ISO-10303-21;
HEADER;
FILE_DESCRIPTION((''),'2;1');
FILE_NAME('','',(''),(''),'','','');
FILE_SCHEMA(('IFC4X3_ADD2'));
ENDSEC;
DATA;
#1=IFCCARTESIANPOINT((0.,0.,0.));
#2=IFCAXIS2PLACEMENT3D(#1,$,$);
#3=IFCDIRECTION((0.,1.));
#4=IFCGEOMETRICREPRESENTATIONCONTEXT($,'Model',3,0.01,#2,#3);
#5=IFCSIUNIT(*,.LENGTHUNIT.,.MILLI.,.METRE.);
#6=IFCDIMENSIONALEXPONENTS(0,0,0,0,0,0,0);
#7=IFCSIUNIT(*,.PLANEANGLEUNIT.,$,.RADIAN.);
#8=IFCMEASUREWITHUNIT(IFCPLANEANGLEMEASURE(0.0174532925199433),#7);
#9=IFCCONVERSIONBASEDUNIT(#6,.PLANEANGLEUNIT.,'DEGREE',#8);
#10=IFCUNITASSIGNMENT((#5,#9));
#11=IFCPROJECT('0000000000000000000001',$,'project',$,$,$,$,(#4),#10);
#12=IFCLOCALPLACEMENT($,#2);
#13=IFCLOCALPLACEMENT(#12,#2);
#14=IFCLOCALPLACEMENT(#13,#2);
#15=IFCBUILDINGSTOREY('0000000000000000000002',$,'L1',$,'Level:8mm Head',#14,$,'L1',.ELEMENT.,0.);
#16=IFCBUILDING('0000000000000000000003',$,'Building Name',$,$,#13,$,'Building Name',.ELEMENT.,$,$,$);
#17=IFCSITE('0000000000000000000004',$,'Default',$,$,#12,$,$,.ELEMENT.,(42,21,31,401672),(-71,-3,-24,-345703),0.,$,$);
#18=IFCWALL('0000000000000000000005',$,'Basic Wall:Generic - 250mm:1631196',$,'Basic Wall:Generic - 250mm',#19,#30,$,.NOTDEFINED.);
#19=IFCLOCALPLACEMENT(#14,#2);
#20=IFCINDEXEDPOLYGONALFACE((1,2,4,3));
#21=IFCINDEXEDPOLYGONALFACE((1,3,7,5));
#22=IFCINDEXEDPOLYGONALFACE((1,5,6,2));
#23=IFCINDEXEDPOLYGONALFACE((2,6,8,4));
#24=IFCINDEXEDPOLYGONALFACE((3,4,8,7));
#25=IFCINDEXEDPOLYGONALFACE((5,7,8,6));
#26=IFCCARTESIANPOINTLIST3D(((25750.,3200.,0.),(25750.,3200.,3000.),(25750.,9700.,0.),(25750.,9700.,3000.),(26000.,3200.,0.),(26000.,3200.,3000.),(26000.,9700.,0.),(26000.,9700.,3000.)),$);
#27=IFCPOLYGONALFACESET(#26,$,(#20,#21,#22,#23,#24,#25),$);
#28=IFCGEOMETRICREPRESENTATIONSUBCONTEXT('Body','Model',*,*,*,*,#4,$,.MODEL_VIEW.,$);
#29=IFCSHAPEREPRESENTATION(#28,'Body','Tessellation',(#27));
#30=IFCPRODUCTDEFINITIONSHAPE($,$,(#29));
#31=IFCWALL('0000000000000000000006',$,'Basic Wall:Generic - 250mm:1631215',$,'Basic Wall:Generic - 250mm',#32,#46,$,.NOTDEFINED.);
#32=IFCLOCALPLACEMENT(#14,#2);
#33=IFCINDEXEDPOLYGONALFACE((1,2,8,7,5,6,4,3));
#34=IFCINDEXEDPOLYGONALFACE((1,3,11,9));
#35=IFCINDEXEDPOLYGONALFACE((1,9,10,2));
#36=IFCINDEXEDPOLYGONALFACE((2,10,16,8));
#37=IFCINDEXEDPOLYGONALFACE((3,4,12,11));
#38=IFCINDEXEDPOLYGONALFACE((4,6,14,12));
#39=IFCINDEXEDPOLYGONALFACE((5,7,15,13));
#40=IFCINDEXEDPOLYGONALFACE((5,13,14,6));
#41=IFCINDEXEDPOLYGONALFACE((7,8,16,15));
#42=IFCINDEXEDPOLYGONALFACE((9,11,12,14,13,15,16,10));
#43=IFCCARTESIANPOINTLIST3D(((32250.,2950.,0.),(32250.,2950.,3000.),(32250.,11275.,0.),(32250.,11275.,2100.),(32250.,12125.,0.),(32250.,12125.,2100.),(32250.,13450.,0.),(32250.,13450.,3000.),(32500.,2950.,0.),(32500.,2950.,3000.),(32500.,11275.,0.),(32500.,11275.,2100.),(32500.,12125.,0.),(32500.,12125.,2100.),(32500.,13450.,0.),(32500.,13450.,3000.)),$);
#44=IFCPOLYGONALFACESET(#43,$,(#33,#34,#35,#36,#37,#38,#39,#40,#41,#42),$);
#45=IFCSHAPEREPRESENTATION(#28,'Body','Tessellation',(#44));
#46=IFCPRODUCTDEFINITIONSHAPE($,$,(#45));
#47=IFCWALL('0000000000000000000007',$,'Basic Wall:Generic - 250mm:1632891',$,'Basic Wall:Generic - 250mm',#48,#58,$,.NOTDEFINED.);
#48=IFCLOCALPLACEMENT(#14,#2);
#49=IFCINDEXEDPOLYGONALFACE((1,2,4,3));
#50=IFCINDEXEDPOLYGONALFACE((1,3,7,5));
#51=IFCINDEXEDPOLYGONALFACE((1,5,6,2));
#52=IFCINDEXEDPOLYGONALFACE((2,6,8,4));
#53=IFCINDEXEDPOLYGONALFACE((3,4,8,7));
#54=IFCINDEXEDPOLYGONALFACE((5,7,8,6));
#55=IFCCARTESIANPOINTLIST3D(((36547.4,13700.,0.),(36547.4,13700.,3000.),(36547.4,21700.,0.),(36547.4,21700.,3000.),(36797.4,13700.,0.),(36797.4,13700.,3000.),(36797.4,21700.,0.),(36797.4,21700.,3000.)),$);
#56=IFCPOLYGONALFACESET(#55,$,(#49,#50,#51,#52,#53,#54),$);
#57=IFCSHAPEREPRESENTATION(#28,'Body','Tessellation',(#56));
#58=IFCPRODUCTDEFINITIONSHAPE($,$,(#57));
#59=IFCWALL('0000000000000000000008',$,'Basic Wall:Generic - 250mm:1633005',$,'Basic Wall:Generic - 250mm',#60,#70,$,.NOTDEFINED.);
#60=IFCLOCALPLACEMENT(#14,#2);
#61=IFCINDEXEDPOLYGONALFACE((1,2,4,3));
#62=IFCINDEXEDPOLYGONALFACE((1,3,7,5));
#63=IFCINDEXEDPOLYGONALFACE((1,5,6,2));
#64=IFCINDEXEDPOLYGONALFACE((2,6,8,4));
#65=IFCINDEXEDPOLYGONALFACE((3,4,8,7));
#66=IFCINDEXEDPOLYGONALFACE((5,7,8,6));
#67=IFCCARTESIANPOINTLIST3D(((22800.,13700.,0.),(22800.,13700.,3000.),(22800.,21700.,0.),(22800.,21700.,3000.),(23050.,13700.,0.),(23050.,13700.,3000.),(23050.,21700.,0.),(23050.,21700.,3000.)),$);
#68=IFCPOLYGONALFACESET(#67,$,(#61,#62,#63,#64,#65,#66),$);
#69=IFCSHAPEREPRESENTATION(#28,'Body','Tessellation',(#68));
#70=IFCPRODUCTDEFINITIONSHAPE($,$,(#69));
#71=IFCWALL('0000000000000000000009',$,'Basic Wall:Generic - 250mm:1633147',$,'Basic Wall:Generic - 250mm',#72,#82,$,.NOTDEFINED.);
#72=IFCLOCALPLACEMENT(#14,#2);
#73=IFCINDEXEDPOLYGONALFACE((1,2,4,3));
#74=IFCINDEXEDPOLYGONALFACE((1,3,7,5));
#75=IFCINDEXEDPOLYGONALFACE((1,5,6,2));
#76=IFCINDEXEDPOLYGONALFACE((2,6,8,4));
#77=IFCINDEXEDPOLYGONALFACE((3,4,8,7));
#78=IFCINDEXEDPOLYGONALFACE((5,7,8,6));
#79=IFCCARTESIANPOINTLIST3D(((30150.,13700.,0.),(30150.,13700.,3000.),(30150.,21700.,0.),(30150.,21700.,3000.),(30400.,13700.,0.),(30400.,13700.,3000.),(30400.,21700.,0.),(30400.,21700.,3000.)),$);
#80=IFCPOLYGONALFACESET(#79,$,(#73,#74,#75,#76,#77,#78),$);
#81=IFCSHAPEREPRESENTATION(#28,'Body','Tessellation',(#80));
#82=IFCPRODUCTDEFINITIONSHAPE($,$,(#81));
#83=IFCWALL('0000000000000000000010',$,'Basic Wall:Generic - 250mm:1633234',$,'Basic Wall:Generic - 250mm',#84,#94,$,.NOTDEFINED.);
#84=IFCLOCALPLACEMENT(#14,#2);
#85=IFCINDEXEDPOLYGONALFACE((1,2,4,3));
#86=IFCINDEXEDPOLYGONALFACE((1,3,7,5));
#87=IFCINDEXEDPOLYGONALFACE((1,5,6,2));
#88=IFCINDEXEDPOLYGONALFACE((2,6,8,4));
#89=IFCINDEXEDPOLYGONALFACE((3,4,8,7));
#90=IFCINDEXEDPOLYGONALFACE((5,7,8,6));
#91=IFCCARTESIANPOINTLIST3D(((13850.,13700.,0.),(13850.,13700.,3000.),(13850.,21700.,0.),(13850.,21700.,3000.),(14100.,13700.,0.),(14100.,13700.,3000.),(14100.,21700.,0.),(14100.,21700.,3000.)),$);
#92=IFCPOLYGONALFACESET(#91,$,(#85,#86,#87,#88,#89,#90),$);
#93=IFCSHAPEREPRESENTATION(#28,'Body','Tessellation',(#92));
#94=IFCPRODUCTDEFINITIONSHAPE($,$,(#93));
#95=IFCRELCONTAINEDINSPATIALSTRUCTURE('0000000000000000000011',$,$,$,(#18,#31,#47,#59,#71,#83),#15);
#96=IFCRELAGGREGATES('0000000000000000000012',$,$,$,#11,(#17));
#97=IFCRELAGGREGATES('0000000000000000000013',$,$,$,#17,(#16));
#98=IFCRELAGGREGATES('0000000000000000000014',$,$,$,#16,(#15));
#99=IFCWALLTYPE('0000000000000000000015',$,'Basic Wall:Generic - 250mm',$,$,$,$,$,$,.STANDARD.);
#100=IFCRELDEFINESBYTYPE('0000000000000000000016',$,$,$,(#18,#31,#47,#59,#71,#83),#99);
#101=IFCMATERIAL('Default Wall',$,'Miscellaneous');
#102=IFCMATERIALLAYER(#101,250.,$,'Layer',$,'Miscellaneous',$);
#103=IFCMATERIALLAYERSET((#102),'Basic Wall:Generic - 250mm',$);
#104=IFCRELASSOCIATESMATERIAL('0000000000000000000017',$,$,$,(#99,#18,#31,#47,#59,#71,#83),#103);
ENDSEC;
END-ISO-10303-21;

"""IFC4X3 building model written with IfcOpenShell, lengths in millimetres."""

from ifc_helpers import new_model, entity, si_unit, converted_unit, direction, frame, frame_2d, origin, place, context, subcontext, project, spatial, rectangle, extrude, material, layer, layer_set, type_object, element, save


model = new_model("IFC4X3")

# Units and contexts
model_context = context("Model", 3, precision=0.01, world=origin(), true_north=direction((0.0, 1.0)))
body_context = subcontext(model_context, "Body", "Model", "MODEL_VIEW")
ifc_project = project(units=[si_unit("LENGTHUNIT", "METRE", prefix="MILLI"), converted_unit("PLANEANGLEUNIT", "DEGREE", entity("IfcPlaneAngleMeasure", 0.0174532925199433), si_unit("PLANEANGLEUNIT", "RADIAN"), dimensions=[0, 0, 0, 0, 0, 0, 0])], contexts=[model_context])

# Site, building, storey
site_placement = place(None, origin())
site = spatial("IfcSite", under=ifc_project, at=site_placement, Name="Default", CompositionType="ELEMENT", RefLatitude=(42, 21, 31, 401672), RefLongitude=(-71, -3, -24, -345703), RefElevation=0.0)
building_placement = place(site_placement, origin())
building = spatial("IfcBuilding", under=site, at=building_placement, Name="Building Name", LongName="Building Name", CompositionType="ELEMENT")
storey_placement = place(building_placement, origin())
storey = spatial("IfcBuildingStorey", under=building, at=storey_placement, Name="L1", ObjectType="Level:8mm Head", LongName="L1", CompositionType="ELEMENT", Elevation=0.0)

# Shared definitions
ifc_material = material(Name="Default Wall", Category="Miscellaneous")
ifc_layer = layer(ifc_material, 250.0, Name="Layer", Category="Miscellaneous")
ifc_layer_set = layer_set([ifc_layer], Name="Basic Wall:Generic - 250mm")
wall_type = type_object("IfcWallType", Name="Basic Wall:Generic - 250mm", PredefinedType="STANDARD", material=ifc_layer_set)

# Wall
wall_1_placement = place(storey_placement, frame((25875.0, 3200.0, 0.0), z_axis=(0.0, 0.0, 1.0), x_axis=(0.0, 1.0, 0.0)))
element("IfcWall", 1, at=wall_1_placement, inside=storey, type_object=wall_type, material=ifc_layer_set, Name="Basic Wall:Generic - 250mm:1631196", ObjectType="Basic Wall:Generic - 250mm", PredefinedType="NOTDEFINED", context=body_context, shape_type="SweptSolid", body=[
    extrude(rectangle(XDim=6500.0, YDim=250.0, at=frame_2d((3250.0, 0.0), x_axis=(-1.0, 0.0))), origin(), (0.0, 0.0, 1.0), 3000.0),
])

# Wall, opening
wall_2_placement = place(storey_placement, frame((32375.0, 2950.0, 0.0), z_axis=(0.0, 0.0, 1.0), x_axis=(0.0, 1.0, 0.0)))
wall_2 = element("IfcWall", 2, at=wall_2_placement, inside=storey, type_object=wall_type, material=ifc_layer_set, Name="Basic Wall:Generic - 250mm:1631215", ObjectType="Basic Wall:Generic - 250mm", PredefinedType="NOTDEFINED", context=body_context, shape_type="SweptSolid", body=[
    extrude(rectangle(XDim=10500.0, YDim=250.0, at=frame_2d((5250.0, 0.0), x_axis=(-1.0, 0.0))), origin(), (0.0, 0.0, 1.0), 3000.0),
])
opening_1_placement = place(wall_2_placement, frame((8325.0, -125.0, 0.0)))
element("IfcOpeningElement", 3, at=opening_1_placement, cuts=wall_2, PredefinedType="OPENING", context=body_context, shape_type="SweptSolid", body=[
    extrude(rectangle(XDim=2100.0, YDim=850.0, at=frame_2d((1050.0, 425.0), x_axis=(1.0, 0.0))), frame((0.0, 0.0, 0.0), z_axis=(0.0, 1.0, 0.0), x_axis=(0.0, 0.0, 1.0)), (0.0, 0.0, 1.0), 250.0),
])

# Walls
wall_3_placement = place(storey_placement, frame((36672.4, 13700.0, 0.0), z_axis=(0.0, 0.0, 1.0), x_axis=(0.0, 1.0, 0.0)))
element("IfcWall", 4, at=wall_3_placement, inside=storey, type_object=wall_type, material=ifc_layer_set, Name="Basic Wall:Generic - 250mm:1632891", ObjectType="Basic Wall:Generic - 250mm", PredefinedType="NOTDEFINED", context=body_context, shape_type="SweptSolid", body=[
    extrude(rectangle(XDim=8000.0, YDim=250.0, at=frame_2d((4000.0, 0.0), x_axis=(-1.0, 0.0))), origin(), (0.0, 0.0, 1.0), 3000.0),
])
for number, where, z_axis, x_axis, name in (
    (5, (22925.0, 21700.0, 0.0), (0.0, 0.0, 1.0), (0.0, -1.0, 0.0), "Basic Wall:Generic - 250mm:1633005"),
    (6, (30275.0, 21700.0, 0.0), (0.0, 0.0, 1.0), (0.0, -1.0, 0.0), "Basic Wall:Generic - 250mm:1633147"),
):
    element("IfcWall", number, at=place(storey_placement, frame(where, z_axis=z_axis, x_axis=x_axis)), inside=storey, type_object=wall_type, material=ifc_layer_set, Name=name, ObjectType="Basic Wall:Generic - 250mm", PredefinedType="NOTDEFINED", context=body_context, shape_type="SweptSolid", body=[
        extrude(rectangle(XDim=8000.0, YDim=250.0, at=frame_2d((4000.0, 0.0), x_axis=(-1.0, 0.0))), origin(), (0.0, 0.0, 1.0), 3000.0),
    ])
wall_4_placement = place(storey_placement, frame((13975.0, 13700.0, 0.0), z_axis=(0.0, 0.0, 1.0), x_axis=(0.0, 1.0, 0.0)))
element("IfcWall", 7, at=wall_4_placement, inside=storey, type_object=wall_type, material=ifc_layer_set, Name="Basic Wall:Generic - 250mm:1633234", ObjectType="Basic Wall:Generic - 250mm", PredefinedType="NOTDEFINED", context=body_context, shape_type="SweptSolid", body=[
    extrude(rectangle(XDim=8000.0, YDim=250.0, at=frame_2d((4000.0, 0.0), x_axis=(-1.0, 0.0))), origin(), (0.0, 0.0, 1.0), 3000.0),
])

save(model, "model.ifc")
